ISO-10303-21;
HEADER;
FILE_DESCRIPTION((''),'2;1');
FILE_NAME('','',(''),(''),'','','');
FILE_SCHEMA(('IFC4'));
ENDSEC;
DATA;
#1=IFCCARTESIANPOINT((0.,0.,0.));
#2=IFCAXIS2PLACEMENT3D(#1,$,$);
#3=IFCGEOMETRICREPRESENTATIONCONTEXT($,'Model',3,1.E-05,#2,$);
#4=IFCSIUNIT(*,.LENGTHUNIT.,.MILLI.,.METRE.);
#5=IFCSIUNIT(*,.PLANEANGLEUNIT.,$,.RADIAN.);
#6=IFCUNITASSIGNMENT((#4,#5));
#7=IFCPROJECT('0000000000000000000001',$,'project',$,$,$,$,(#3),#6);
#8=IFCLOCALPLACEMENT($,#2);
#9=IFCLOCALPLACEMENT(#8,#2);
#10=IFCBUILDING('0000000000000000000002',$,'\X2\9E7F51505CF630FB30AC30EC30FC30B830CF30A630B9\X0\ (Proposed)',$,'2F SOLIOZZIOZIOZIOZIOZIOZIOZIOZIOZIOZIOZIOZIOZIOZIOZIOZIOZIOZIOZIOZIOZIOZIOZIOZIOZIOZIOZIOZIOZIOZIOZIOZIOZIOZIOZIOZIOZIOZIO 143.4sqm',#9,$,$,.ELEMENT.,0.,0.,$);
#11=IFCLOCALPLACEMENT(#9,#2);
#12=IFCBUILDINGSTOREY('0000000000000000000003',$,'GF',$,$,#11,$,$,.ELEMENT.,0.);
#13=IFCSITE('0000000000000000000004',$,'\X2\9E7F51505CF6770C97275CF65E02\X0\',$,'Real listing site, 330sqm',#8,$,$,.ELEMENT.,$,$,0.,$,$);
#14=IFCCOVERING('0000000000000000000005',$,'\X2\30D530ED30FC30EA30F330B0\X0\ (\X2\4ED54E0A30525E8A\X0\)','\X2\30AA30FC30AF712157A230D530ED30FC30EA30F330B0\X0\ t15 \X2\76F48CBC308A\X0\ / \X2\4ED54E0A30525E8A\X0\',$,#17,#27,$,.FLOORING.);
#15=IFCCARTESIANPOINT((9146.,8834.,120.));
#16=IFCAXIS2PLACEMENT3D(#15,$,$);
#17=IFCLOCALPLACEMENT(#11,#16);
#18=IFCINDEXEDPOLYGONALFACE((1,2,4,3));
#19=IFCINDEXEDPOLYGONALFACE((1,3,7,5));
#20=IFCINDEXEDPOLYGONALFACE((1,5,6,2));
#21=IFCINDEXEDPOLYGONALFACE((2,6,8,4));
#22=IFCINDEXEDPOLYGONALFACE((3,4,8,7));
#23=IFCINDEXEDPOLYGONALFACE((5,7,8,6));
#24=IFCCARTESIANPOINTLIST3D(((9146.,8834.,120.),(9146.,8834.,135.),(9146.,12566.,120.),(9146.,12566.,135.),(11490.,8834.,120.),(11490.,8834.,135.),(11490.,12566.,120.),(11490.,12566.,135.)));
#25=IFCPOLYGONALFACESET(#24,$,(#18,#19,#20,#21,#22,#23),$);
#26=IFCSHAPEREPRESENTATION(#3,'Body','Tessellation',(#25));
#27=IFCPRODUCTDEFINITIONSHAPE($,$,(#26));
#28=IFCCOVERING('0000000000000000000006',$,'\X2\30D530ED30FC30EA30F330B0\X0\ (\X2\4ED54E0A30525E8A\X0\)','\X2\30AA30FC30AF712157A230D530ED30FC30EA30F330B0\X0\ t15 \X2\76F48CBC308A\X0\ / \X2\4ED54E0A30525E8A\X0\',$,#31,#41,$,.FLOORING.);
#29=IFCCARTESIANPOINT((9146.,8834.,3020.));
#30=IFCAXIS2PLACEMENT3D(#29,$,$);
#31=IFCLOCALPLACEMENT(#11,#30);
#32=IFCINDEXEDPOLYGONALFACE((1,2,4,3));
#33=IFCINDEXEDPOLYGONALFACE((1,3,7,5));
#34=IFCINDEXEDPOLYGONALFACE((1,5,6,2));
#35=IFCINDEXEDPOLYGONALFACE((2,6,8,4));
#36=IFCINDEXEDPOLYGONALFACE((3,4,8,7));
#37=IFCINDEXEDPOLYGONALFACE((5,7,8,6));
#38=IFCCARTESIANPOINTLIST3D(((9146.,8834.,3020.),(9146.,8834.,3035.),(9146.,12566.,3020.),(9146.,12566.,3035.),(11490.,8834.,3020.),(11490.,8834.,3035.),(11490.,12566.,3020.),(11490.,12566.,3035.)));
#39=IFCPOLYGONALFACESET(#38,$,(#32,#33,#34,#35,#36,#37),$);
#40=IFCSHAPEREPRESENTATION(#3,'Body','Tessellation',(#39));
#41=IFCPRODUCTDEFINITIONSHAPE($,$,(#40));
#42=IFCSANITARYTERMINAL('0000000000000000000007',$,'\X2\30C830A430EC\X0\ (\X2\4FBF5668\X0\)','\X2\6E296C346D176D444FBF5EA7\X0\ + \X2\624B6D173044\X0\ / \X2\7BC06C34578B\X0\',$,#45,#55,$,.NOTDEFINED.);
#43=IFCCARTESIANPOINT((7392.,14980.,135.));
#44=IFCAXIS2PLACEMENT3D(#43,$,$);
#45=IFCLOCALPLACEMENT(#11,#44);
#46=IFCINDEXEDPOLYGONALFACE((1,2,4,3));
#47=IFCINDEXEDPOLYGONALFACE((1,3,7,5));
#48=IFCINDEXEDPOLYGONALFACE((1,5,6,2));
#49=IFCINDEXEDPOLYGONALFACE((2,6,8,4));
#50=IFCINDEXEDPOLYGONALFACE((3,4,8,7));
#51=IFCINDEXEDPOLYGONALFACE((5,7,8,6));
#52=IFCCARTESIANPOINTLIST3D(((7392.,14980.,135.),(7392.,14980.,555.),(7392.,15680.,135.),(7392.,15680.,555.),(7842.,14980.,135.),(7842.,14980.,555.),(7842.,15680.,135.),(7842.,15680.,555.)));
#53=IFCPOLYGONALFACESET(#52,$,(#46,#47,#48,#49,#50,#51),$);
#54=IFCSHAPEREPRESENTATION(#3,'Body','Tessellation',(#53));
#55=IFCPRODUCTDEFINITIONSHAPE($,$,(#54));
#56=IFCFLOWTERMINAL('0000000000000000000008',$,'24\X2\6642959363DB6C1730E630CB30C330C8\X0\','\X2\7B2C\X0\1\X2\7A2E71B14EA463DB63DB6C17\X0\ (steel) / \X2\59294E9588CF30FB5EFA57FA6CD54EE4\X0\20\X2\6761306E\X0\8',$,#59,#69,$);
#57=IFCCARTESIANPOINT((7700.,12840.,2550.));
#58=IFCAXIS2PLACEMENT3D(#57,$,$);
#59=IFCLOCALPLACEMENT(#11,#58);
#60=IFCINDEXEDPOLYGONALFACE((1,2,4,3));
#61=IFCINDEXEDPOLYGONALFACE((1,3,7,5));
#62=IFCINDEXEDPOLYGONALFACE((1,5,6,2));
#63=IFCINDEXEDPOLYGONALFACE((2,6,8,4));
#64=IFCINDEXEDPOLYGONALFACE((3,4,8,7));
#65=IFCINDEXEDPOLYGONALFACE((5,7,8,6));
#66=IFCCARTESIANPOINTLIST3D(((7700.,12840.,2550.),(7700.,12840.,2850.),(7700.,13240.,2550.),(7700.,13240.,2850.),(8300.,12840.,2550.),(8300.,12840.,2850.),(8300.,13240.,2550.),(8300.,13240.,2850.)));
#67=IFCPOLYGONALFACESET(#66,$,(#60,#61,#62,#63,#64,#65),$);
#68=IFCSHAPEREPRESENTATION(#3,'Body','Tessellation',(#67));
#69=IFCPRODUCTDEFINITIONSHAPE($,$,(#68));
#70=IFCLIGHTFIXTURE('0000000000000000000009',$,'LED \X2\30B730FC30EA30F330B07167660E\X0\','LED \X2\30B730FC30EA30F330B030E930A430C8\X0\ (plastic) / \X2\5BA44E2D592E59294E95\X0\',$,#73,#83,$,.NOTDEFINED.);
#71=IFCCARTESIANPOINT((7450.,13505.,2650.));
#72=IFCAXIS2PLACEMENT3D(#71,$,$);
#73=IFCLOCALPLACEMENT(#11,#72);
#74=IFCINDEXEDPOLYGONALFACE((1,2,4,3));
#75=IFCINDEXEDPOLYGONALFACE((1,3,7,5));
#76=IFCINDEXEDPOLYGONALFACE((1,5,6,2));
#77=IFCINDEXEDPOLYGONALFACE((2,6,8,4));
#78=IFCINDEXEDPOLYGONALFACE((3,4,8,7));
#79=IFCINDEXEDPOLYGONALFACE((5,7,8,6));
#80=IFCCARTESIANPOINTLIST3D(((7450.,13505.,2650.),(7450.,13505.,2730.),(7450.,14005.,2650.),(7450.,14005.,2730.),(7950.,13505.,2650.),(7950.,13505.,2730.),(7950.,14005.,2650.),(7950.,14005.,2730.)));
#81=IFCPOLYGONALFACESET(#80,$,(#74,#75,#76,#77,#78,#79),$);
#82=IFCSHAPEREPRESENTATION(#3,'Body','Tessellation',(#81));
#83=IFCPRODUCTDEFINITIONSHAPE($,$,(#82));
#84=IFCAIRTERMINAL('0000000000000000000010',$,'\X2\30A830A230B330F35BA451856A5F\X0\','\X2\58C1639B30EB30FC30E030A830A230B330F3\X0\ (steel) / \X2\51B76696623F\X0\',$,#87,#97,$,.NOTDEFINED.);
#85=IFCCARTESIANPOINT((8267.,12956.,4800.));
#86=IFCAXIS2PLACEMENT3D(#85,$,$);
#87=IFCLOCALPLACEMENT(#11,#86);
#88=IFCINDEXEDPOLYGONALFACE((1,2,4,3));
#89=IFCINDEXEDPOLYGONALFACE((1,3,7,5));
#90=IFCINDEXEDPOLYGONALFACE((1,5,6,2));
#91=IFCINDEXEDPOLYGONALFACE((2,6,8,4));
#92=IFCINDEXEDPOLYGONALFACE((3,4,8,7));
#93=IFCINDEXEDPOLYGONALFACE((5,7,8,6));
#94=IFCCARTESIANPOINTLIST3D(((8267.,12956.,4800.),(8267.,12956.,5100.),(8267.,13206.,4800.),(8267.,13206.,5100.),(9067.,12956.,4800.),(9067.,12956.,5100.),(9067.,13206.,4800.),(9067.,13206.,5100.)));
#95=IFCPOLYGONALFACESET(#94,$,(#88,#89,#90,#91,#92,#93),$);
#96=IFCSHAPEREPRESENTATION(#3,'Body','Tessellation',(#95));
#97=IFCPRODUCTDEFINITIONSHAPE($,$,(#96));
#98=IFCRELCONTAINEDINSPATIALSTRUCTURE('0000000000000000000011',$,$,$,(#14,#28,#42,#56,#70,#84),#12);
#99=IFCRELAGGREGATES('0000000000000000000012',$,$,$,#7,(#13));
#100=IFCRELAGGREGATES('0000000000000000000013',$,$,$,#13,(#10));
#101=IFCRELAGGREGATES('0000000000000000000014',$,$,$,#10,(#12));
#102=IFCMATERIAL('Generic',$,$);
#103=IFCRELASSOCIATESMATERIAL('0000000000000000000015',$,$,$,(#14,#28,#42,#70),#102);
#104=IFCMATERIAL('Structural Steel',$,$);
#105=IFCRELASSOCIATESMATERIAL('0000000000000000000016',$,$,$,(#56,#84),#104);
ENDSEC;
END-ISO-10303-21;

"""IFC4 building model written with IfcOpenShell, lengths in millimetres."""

from ifc_helpers import new_model, si_unit, frame, frame_2d, origin, place, context, project, spatial, rectangle, extrude, material, element, save


model = new_model("IFC4")

# Units and contexts
model_context = context("Model", 3, precision=1e-05, world=origin())
ifc_project = project(units=[si_unit("LENGTHUNIT", "METRE", prefix="MILLI"), si_unit("PLANEANGLEUNIT", "RADIAN")], contexts=[model_context])

# Site, building, storey
site_placement = place(None, origin())
site = spatial("IfcSite", under=ifc_project, at=site_placement, Name="鹿児島県霧島市", ObjectType="Real listing site, 330sqm", CompositionType="ELEMENT", RefElevation=0.0)
building_placement = place(site_placement, origin())
building = spatial("IfcBuilding", under=site, at=building_placement, Name="鹿児島・ガレージハウス (Proposed)", ObjectType="2F SOLIOZZIOZIOZIOZIOZIOZIOZIOZIOZIOZIOZIOZIOZIOZIOZIOZIOZIOZIOZIOZIOZIOZIOZIOZIOZIOZIOZIOZIOZIOZIOZIOZIOZIOZIOZIOZIOZIOZIO 143.4sqm", CompositionType="ELEMENT", ElevationOfRefHeight=0.0, ElevationOfTerrain=0.0)
storey_placement = place(building_placement, origin())
storey = spatial("IfcBuildingStorey", under=building, at=storey_placement, Name="GF", CompositionType="ELEMENT", Elevation=0.0)

# Coverings
ifc_material_1 = material(Name="Generic")
covering_1_placement = place(storey_placement, frame((9146.0, 8834.0, 120.0)))
element("IfcCovering", 1, at=covering_1_placement, inside=storey, material=ifc_material_1, Name="フローリング (仕上げ床)", Description="オーク無垢フローリング t15 直貼り / 仕上げ床", PredefinedType="FLOORING", context=model_context, shape_type="SweptSolid", body=[
    extrude(rectangle(XDim=2344.0, YDim=3732.0, at=frame_2d((1172.0, 1866.0))), frame((9146.0, 8834.0, 120.0)), (0.0, 0.0, 1.0), 15.0),
])
covering_2_placement = place(storey_placement, frame((9146.0, 8834.0, 3020.0)))
element("IfcCovering", 2, at=covering_2_placement, inside=storey, material=ifc_material_1, Name="フローリング (仕上げ床)", Description="オーク無垢フローリング t15 直貼り / 仕上げ床", PredefinedType="FLOORING", context=model_context, shape_type="SweptSolid", body=[
    extrude(rectangle(XDim=2344.0, YDim=3732.0, at=frame_2d((1172.0, 1866.0))), frame((9146.0, 8834.0, 3020.0)), (0.0, 0.0, 1.0), 15.0),
])

# Sanitary terminal
sanitary_terminal_placement = place(storey_placement, frame((7392.0, 14980.0, 135.0)))
element("IfcSanitaryTerminal", 3, at=sanitary_terminal_placement, inside=storey, material=ifc_material_1, Name="トイレ (便器)", Description="温水洗浄便座 + 手洗い / 節水型", PredefinedType="NOTDEFINED", context=model_context, shape_type="SweptSolid", body=[
    extrude(rectangle(XDim=450.0, YDim=700.0, at=frame_2d((225.0, 350.0))), frame((7392.0, 14980.0, 135.0)), (0.0, 0.0, 1.0), 420.0),
])

# Flow terminal
ifc_material_2 = material(Name="Structural Steel")
flow_terminal_placement = place(storey_placement, frame((7700.0, 12840.0, 2550.0)))
element("IfcFlowTerminal", 4, at=flow_terminal_placement, inside=storey, material=ifc_material_2, Name="24時間換気ユニット", Description="第1種熱交換換気 (steel) / 天井裏・建基法令20条の8", context=model_context, shape_type="SweptSolid", body=[
    extrude(rectangle(XDim=600.0, YDim=400.0, at=frame_2d((300.0, 200.0))), frame((7700.0, 12840.0, 2550.0)), (0.0, 0.0, 1.0), 300.0),
])

# Light fixture
light_fixture_placement = place(storey_placement, frame((7450.0, 13505.0, 2650.0)))
element("IfcLightFixture", 5, at=light_fixture_placement, inside=storey, material=ifc_material_1, Name="LED シーリング照明", Description="LED シーリングライト (plastic) / 室中央天井", PredefinedType="NOTDEFINED", context=model_context, shape_type="SweptSolid", body=[
    extrude(rectangle(XDim=500.0, YDim=500.0, at=frame_2d((250.0, 250.0))), frame((7450.0, 13505.0, 2650.0)), (0.0, 0.0, 1.0), 80.0),
])

# Air terminal
air_terminal_placement = place(storey_placement, frame((8267.0, 12956.0, 4800.0)))
element("IfcAirTerminal", 6, at=air_terminal_placement, inside=storey, material=ifc_material_2, Name="エアコン室内機", Description="壁掛ルームエアコン (steel) / 冷暖房", PredefinedType="NOTDEFINED", context=model_context, shape_type="SweptSolid", body=[
    extrude(rectangle(XDim=800.0, YDim=250.0, at=frame_2d((400.0, 125.0))), frame((8267.0, 12956.0, 4800.0)), (0.0, 0.0, 1.0), 300.0),
])

save(model, "model.ifc")
